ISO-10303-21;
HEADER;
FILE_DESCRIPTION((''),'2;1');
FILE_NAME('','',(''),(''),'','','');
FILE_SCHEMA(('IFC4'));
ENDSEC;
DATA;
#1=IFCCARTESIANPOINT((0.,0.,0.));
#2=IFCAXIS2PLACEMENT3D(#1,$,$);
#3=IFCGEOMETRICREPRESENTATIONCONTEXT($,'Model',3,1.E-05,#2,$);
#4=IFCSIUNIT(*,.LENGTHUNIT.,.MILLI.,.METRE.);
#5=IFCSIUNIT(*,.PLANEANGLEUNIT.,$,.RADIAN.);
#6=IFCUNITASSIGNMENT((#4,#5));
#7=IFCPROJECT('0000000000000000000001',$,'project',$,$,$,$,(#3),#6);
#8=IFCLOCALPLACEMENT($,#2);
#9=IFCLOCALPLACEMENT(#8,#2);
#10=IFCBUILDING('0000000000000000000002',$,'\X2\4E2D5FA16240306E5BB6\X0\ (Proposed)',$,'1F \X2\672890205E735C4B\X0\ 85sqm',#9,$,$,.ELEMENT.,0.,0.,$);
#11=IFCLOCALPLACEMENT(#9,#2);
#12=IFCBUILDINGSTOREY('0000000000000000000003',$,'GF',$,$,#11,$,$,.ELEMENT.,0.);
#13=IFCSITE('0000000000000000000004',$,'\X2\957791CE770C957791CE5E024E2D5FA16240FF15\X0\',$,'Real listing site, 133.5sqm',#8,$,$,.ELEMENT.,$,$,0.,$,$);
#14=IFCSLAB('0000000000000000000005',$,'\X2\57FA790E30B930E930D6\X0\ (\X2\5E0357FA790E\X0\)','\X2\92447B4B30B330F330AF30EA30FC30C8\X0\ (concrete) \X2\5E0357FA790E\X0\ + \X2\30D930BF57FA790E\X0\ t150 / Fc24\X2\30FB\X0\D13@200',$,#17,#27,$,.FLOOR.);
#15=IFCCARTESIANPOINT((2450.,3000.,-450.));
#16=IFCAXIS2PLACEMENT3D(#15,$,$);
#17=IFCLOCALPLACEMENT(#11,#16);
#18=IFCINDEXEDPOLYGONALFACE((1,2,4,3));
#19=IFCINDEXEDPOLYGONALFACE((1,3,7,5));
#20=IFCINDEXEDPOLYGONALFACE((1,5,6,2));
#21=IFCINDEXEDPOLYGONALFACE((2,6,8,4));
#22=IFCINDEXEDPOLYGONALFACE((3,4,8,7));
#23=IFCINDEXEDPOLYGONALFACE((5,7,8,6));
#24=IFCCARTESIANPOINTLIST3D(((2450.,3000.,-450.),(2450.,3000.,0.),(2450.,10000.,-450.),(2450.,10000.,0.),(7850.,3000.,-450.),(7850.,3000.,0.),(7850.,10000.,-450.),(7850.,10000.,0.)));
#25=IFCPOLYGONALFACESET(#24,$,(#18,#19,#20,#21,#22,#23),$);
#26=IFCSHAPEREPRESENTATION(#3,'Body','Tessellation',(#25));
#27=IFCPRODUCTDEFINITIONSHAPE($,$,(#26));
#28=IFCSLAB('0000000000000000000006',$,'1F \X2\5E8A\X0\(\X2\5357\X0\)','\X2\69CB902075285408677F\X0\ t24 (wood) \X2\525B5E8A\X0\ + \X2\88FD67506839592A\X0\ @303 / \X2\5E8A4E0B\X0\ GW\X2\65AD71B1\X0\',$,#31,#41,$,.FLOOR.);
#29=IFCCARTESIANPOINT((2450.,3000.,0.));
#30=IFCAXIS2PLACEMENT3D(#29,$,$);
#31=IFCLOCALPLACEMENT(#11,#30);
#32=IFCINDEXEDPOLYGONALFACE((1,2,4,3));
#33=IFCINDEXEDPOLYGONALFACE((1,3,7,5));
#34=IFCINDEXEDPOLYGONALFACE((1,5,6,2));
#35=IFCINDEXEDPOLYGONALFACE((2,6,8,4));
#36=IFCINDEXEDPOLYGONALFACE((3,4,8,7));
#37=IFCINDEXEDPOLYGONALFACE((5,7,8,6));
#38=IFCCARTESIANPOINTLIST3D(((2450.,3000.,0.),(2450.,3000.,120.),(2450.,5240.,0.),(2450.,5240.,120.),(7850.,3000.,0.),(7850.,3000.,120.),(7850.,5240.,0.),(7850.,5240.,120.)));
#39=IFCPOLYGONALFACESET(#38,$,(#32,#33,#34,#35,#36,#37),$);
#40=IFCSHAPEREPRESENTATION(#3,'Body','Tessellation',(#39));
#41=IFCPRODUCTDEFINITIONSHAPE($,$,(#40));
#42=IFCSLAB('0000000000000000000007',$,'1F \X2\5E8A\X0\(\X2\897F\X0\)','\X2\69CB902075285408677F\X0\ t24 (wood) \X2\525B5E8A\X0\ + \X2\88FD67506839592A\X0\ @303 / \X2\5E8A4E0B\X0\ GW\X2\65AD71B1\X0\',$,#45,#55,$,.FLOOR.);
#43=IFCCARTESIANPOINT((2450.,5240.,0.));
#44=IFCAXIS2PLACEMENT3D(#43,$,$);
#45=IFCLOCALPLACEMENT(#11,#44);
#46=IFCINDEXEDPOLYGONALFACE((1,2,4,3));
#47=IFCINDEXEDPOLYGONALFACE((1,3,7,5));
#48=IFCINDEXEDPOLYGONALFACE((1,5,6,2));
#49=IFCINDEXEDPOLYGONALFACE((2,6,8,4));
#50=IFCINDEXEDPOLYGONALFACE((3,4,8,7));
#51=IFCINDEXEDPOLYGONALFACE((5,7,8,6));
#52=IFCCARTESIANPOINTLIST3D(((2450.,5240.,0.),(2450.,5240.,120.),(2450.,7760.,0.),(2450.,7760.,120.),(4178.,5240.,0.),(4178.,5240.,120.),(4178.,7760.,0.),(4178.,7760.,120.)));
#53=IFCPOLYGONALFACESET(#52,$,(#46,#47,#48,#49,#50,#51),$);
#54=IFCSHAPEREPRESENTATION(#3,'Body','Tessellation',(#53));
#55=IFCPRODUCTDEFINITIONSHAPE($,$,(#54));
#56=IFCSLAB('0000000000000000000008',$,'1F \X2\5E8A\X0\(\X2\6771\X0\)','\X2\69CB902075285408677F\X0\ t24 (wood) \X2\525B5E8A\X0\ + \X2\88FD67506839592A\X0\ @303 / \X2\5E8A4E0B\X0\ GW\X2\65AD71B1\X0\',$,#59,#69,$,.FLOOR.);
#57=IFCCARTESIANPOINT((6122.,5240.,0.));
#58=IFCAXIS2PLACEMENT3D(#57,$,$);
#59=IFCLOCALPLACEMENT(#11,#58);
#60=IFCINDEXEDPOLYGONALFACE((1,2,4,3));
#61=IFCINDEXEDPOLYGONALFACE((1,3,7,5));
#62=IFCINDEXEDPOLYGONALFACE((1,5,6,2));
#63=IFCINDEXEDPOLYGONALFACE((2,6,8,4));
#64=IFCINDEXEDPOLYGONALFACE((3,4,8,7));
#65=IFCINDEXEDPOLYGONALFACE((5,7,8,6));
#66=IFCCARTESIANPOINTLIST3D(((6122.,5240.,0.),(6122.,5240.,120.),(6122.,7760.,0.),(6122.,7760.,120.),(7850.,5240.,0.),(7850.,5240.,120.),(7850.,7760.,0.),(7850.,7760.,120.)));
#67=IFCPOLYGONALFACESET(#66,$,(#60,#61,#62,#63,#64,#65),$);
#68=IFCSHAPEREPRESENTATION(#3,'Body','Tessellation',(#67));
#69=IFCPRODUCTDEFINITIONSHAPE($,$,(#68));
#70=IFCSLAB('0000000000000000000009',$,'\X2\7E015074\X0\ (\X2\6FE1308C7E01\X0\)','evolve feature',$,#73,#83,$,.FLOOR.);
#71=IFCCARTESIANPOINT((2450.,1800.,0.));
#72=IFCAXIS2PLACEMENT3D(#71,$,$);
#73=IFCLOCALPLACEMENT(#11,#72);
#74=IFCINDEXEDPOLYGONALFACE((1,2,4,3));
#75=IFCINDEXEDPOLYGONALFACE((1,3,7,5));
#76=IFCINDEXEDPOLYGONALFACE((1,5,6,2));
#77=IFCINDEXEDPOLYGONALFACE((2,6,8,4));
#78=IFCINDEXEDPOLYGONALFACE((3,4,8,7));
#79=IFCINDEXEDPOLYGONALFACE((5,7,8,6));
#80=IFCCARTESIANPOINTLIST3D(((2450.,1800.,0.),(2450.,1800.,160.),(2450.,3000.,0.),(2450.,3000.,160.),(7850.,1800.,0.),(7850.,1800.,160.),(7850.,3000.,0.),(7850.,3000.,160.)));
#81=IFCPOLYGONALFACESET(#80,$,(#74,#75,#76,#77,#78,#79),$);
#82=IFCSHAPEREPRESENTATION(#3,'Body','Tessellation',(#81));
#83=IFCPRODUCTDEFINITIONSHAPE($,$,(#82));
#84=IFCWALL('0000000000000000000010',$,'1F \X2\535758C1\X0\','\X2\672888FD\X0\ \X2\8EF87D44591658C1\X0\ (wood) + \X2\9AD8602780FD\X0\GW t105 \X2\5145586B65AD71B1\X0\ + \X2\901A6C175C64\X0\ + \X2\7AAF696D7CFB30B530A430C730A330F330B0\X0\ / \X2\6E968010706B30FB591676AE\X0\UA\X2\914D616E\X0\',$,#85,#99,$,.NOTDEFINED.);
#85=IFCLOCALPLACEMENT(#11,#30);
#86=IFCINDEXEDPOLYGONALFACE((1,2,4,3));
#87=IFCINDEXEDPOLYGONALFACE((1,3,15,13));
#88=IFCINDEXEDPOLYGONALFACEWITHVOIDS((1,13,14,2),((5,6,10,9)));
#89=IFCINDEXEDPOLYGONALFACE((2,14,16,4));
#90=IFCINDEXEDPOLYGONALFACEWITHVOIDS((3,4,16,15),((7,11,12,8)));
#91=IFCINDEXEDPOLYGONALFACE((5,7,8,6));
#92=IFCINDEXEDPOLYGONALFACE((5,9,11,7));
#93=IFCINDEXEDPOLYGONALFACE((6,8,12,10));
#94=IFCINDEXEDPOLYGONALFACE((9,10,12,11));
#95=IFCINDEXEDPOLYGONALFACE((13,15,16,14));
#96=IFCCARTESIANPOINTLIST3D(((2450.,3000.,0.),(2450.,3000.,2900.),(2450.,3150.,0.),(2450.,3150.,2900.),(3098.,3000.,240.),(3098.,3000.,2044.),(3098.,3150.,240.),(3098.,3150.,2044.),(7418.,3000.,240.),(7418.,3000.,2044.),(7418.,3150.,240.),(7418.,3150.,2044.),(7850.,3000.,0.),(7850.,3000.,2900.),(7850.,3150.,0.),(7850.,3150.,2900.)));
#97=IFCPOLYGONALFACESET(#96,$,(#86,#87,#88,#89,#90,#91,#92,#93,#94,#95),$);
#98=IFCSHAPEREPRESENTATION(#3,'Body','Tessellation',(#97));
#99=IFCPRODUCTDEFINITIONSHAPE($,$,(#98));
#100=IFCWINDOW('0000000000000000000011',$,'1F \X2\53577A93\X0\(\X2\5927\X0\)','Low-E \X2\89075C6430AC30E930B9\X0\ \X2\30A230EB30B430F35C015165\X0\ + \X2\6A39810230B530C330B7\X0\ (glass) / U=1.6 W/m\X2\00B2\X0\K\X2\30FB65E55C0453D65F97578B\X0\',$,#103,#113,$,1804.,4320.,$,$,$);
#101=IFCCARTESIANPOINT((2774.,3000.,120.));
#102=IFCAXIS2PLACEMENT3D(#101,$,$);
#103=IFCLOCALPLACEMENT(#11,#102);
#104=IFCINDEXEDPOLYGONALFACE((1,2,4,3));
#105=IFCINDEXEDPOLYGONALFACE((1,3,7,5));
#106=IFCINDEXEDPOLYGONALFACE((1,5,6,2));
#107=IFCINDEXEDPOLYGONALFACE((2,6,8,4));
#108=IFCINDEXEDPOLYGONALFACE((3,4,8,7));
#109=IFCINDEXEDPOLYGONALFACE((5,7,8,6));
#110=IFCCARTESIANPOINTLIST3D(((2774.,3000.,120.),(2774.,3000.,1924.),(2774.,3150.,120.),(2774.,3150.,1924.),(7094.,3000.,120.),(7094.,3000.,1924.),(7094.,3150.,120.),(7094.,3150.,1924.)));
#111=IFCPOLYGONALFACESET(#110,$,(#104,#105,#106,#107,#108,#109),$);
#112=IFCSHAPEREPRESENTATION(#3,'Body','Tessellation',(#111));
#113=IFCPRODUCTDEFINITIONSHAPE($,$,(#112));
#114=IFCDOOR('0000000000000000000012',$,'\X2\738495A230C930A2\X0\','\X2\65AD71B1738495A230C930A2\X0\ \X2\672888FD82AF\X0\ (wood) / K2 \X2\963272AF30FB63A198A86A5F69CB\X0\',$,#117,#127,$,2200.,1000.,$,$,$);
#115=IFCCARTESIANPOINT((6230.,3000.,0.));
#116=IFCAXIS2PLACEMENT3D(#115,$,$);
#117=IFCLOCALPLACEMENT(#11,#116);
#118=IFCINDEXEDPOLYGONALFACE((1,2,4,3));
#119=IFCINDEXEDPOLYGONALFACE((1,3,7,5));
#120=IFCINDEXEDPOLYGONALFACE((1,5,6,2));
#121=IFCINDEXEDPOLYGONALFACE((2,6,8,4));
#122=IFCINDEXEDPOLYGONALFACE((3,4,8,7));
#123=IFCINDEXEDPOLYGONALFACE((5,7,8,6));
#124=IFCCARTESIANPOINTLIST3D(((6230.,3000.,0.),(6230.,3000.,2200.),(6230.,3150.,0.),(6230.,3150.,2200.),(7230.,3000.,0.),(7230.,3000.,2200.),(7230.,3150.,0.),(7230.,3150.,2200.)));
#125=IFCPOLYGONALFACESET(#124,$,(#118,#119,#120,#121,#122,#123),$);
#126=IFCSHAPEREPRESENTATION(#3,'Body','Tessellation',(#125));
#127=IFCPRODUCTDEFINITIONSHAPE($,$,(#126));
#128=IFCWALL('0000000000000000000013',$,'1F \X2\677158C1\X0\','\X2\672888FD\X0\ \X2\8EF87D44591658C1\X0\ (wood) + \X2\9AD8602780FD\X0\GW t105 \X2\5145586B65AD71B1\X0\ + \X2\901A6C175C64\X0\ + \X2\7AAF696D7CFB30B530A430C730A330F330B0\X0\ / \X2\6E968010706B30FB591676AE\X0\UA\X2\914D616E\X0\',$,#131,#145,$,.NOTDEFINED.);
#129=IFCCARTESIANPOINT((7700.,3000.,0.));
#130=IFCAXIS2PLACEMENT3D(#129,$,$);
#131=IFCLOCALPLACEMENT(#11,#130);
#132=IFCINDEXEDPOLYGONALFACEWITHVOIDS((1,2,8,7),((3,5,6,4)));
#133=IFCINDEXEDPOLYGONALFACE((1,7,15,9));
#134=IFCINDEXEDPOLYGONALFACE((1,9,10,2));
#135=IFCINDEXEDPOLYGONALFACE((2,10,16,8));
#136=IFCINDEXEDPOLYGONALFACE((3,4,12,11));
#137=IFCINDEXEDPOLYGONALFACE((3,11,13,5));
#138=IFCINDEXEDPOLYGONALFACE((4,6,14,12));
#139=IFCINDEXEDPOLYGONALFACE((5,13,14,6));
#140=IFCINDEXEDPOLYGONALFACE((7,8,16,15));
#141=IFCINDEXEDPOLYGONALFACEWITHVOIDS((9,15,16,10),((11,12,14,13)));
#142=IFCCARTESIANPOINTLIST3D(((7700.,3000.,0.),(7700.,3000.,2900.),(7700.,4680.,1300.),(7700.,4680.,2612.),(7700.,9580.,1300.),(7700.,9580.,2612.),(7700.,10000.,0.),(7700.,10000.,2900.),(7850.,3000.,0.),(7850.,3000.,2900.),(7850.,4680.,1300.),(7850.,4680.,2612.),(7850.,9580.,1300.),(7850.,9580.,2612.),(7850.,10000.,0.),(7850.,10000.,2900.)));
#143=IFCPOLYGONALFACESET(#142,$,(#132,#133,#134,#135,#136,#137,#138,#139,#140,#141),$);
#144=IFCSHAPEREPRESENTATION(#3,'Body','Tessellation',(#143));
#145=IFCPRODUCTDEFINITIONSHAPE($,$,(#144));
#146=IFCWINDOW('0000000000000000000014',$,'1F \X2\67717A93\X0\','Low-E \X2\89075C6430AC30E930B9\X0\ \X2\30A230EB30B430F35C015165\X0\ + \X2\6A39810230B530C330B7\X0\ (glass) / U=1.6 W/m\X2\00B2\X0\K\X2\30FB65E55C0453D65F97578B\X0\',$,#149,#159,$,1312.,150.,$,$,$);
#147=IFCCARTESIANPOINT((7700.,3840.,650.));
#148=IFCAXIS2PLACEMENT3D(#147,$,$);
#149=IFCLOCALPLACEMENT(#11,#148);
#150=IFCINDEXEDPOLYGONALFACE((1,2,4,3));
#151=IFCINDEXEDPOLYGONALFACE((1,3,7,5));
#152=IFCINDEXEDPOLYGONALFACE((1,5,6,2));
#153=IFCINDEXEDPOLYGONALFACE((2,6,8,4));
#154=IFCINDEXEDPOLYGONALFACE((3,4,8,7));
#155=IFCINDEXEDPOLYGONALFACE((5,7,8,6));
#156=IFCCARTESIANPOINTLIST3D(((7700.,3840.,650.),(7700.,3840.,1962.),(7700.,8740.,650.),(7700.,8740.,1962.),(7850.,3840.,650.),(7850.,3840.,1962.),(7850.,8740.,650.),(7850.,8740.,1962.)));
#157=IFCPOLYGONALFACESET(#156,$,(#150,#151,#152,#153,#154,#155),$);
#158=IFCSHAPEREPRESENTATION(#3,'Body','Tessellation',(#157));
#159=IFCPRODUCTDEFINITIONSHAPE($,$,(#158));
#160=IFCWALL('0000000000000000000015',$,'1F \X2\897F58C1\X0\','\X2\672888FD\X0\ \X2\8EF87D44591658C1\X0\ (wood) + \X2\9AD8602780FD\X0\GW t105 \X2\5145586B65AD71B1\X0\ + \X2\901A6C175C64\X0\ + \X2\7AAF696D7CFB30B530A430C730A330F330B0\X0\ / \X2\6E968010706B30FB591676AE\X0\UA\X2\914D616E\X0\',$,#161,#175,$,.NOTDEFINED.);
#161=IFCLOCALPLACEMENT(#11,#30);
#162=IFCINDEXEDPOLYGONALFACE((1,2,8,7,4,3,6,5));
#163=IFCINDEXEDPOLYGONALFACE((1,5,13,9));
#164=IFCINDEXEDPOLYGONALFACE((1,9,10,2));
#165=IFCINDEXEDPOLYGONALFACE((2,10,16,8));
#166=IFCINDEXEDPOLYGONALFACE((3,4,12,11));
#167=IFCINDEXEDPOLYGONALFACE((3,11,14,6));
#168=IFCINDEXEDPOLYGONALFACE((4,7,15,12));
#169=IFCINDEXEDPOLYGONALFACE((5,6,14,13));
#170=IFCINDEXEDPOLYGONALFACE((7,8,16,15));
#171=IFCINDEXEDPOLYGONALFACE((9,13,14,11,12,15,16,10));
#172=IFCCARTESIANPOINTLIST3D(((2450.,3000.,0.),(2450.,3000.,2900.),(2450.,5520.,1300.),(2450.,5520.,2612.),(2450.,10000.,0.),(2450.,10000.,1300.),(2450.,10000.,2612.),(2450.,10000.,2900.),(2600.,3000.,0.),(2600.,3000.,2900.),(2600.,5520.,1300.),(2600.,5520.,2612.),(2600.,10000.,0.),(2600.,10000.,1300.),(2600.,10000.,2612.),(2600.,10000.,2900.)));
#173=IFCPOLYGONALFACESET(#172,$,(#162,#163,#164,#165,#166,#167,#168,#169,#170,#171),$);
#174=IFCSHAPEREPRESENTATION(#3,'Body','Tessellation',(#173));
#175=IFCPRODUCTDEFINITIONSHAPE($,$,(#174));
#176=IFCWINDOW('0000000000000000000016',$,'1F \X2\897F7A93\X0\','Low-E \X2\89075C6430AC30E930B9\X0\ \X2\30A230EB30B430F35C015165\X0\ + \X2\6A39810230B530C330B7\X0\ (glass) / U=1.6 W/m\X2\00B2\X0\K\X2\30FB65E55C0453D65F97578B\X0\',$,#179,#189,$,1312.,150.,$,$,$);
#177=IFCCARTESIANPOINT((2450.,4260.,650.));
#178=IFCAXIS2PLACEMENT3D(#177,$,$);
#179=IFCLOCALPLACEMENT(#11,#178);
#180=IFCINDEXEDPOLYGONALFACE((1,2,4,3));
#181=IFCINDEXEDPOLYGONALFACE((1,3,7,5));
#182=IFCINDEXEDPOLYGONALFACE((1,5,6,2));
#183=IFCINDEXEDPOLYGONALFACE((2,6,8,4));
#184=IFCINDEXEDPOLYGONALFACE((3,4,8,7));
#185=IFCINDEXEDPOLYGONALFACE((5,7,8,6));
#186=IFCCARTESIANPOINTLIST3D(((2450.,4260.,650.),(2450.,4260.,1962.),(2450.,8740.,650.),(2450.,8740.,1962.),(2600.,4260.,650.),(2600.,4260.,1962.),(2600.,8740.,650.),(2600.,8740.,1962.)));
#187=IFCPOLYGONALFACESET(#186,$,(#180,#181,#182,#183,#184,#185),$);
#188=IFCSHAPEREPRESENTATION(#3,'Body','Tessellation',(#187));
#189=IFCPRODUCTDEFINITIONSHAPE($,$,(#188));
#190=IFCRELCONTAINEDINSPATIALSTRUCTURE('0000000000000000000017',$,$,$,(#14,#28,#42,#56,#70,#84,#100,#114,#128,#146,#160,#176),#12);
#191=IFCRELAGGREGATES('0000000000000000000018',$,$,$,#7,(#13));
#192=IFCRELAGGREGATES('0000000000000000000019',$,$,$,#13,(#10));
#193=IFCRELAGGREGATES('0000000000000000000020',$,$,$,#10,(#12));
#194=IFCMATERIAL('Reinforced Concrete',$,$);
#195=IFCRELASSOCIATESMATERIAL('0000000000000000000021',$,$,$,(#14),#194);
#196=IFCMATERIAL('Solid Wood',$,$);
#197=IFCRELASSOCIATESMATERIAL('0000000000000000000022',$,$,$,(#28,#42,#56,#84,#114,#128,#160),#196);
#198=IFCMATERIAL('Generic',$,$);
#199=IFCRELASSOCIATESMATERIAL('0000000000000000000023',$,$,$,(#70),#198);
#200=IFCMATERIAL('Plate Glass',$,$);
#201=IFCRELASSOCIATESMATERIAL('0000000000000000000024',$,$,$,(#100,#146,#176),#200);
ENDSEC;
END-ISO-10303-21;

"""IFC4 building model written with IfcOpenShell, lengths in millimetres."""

from ifc_helpers import new_model, si_unit, frame, frame_2d, origin, place, context, project, spatial, rectangle, extrude, material, element, fill, save


model = new_model("IFC4")

# Units and contexts
model_context = context("Model", 3, precision=1e-05, world=origin())
ifc_project = project(units=[si_unit("LENGTHUNIT", "METRE", prefix="MILLI"), si_unit("PLANEANGLEUNIT", "RADIAN")], contexts=[model_context])

# Site, building, storey
site_placement = place(None, origin())
site = spatial("IfcSite", under=ifc_project, at=site_placement, Name="長野県長野市中御所５", ObjectType="Real listing site, 133.5sqm", CompositionType="ELEMENT", RefElevation=0.0)
building_placement = place(site_placement, origin())
building = spatial("IfcBuilding", under=site, at=building_placement, Name="中御所の家 (Proposed)", ObjectType="1F 木造平屋 85sqm", CompositionType="ELEMENT", ElevationOfRefHeight=0.0, ElevationOfTerrain=0.0)
storey_placement = place(building_placement, origin())
storey = spatial("IfcBuildingStorey", under=building, at=storey_placement, Name="GF", CompositionType="ELEMENT", Elevation=0.0)

# Slabs
ifc_material_1 = material(Name="Reinforced Concrete")
slab_1_placement = place(storey_placement, frame((2450.0, 3000.0, -450.0)))
element("IfcSlab", 1, at=slab_1_placement, inside=storey, material=ifc_material_1, Name="基礎スラブ (布基礎)", Description="鉄筋コンクリート (concrete) 布基礎 + ベタ基礎 t150 / Fc24・D13@200", PredefinedType="FLOOR", context=model_context, shape_type="SweptSolid", body=[
    extrude(rectangle(XDim=5400.0, YDim=7000.0, at=frame_2d((2700.0, 3500.0))), frame((2450.0, 3000.0, -450.0)), (0.0, 0.0, 1.0), 450.0),
])
ifc_material_2 = material(Name="Solid Wood")
slab_2_placement = place(storey_placement, frame((2450.0, 3000.0, 0.0)))
element("IfcSlab", 2, at=slab_2_placement, inside=storey, material=ifc_material_2, Name="1F 床(南)", Description="構造用合板 t24 (wood) 剛床 + 製材根太 @303 / 床下 GW断熱", PredefinedType="FLOOR", context=model_context, shape_type="SweptSolid", body=[
    extrude(rectangle(XDim=5400.0, YDim=2240.0, at=frame_2d((2700.0, 1120.0))), frame((2450.0, 3000.0, 0.0)), (0.0, 0.0, 1.0), 120.0),
])
slab_3_placement = place(storey_placement, frame((2450.0, 5240.0, 0.0)))
element("IfcSlab", 3, at=slab_3_placement, inside=storey, material=ifc_material_2, Name="1F 床(西)", Description="構造用合板 t24 (wood) 剛床 + 製材根太 @303 / 床下 GW断熱", PredefinedType="FLOOR", context=model_context, shape_type="SweptSolid", body=[
    extrude(rectangle(XDim=1728.0, YDim=2520.0, at=frame_2d((864.0, 1260.0))), frame((2450.0, 5240.0, 0.0)), (0.0, 0.0, 1.0), 120.0),
])
slab_4_placement = place(storey_placement, frame((6122.0, 5240.0, 0.0)))
element("IfcSlab", 4, at=slab_4_placement, inside=storey, material=ifc_material_2, Name="1F 床(東)", Description="構造用合板 t24 (wood) 剛床 + 製材根太 @303 / 床下 GW断熱", PredefinedType="FLOOR", context=model_context, shape_type="SweptSolid", body=[
    extrude(rectangle(XDim=1728.0, YDim=2520.0, at=frame_2d((864.0, 1260.0))), frame((6122.0, 5240.0, 0.0)), (0.0, 0.0, 1.0), 120.0),
])
ifc_material_3 = material(Name="Generic")
slab_5_placement = place(storey_placement, frame((2450.0, 1800.0, 0.0)))
element("IfcSlab", 5, at=slab_5_placement, inside=storey, material=ifc_material_3, Name="縁側 (濡れ縁)", Description="evolve feature", PredefinedType="FLOOR", context=model_context, shape_type="SweptSolid", body=[
    extrude(rectangle(XDim=5400.0, YDim=1200.0, at=frame_2d((2700.0, 600.0))), frame((2450.0, 1800.0, 0.0)), (0.0, 0.0, 1.0), 160.0),
])

# Wall, openings, window, door
wall_1_placement = place(storey_placement, frame((2450.0, 3000.0, 0.0)))
wall_1 = element("IfcWall", 6, at=wall_1_placement, inside=storey, material=ifc_material_2, Name="1F 南壁", Description="木製 軸組外壁 (wood) + 高性能GW t105 充填断熱 + 通気層 + 窯業系サイディング / 準耐火・外皮UA配慮", PredefinedType="NOTDEFINED", context=model_context, shape_type="SweptSolid", body=[
    extrude(rectangle(XDim=5400.0, YDim=150.0, at=frame_2d((2700.0, 75.0))), frame((2450.0, 3000.0, 0.0)), (0.0, 0.0, 1.0), 2900.0),
])
opening_1_placement = place(storey_placement, frame((2774.0, 3000.0, 120.0)))
opening_1 = element("IfcOpeningElement", 7, at=opening_1_placement, cuts=wall_1, PredefinedType="NOTDEFINED", context=model_context, shape_type="SweptSolid", body=[
    extrude(rectangle(XDim=4320.0, YDim=150.0, at=frame_2d((2160.0, 75.0))), frame((2774.0, 3000.0, 120.0)), (0.0, 0.0, 1.0), 1804.0),
])
opening_2_placement = place(storey_placement, frame((6230.0, 3000.0, 0.0)))
opening_2 = element("IfcOpeningElement", 8, at=opening_2_placement, cuts=wall_1, PredefinedType="NOTDEFINED", context=model_context, shape_type="SweptSolid", body=[
    extrude(rectangle(XDim=1000.0, YDim=150.0, at=frame_2d((500.0, 75.0))), frame((6230.0, 3000.0, 0.0)), (0.0, 0.0, 1.0), 2200.0),
])
ifc_material_4 = material(Name="Plate Glass")
window_1_placement = place(storey_placement, frame((2774.0, 3000.0, 120.0)))
window_1 = element("IfcWindow", 9, at=window_1_placement, inside=storey, material=ifc_material_4, Name="1F 南窓(大)", Description="Low-E 複層ガラス アルゴン封入 + 樹脂サッシ (glass) / U=1.6 W/m²K・日射取得型", OverallHeight=1804.0, OverallWidth=4320.0, context=model_context, shape_type="SweptSolid", body=[
    extrude(rectangle(XDim=4320.0, YDim=150.0, at=frame_2d((2160.0, 75.0))), frame((2774.0, 3000.0, 120.0)), (0.0, 0.0, 1.0), 1804.0),
])
fill(opening_1, window_1)
door_placement = place(storey_placement, frame((6230.0, 3000.0, 0.0)))
door = element("IfcDoor", 10, at=door_placement, inside=storey, material=ifc_material_2, Name="玄関ドア", Description="断熱玄関ドア 木製芯 (wood) / K2 防犯・採風機構", OverallHeight=2200.0, OverallWidth=1000.0, context=model_context, shape_type="SweptSolid", body=[
    extrude(rectangle(XDim=1000.0, YDim=150.0, at=frame_2d((500.0, 75.0))), frame((6230.0, 3000.0, 0.0)), (0.0, 0.0, 1.0), 2200.0),
])
fill(opening_2, door)

# Walls, openings, windows
wall_2_placement = place(storey_placement, frame((7700.0, 3000.0, 0.0)))
wall_2 = element("IfcWall", 11, at=wall_2_placement, inside=storey, material=ifc_material_2, Name="1F 東壁", Description="木製 軸組外壁 (wood) + 高性能GW t105 充填断熱 + 通気層 + 窯業系サイディング / 準耐火・外皮UA配慮", PredefinedType="NOTDEFINED", context=model_context, shape_type="SweptSolid", body=[
    extrude(rectangle(XDim=150.0, YDim=7000.0, at=frame_2d((75.0, 3500.0))), frame((7700.0, 3000.0, 0.0)), (0.0, 0.0, 1.0), 2900.0),
])
opening_3_placement = place(storey_placement, frame((7700.0, 3840.0, 650.0)))
opening_3 = element("IfcOpeningElement", 12, at=opening_3_placement, cuts=wall_2, PredefinedType="NOTDEFINED", context=model_context, shape_type="SweptSolid", body=[
    extrude(rectangle(XDim=150.0, YDim=4900.0, at=frame_2d((75.0, 2450.0))), frame((7700.0, 3840.0, 650.0)), (0.0, 0.0, 1.0), 1312.0),
])
window_2_placement = place(storey_placement, frame((7700.0, 3840.0, 650.0)))
window_2 = element("IfcWindow", 13, at=window_2_placement, inside=storey, material=ifc_material_4, Name="1F 東窓", Description="Low-E 複層ガラス アルゴン封入 + 樹脂サッシ (glass) / U=1.6 W/m²K・日射取得型", OverallHeight=1312.0, OverallWidth=150.0, context=model_context, shape_type="SweptSolid", body=[
    extrude(rectangle(XDim=150.0, YDim=4900.0, at=frame_2d((75.0, 2450.0))), frame((7700.0, 3840.0, 650.0)), (0.0, 0.0, 1.0), 1312.0),
])
fill(opening_3, window_2)
wall_3_placement = place(storey_placement, frame((2450.0, 3000.0, 0.0)))
wall_3 = element("IfcWall", 14, at=wall_3_placement, inside=storey, material=ifc_material_2, Name="1F 西壁", Description="木製 軸組外壁 (wood) + 高性能GW t105 充填断熱 + 通気層 + 窯業系サイディング / 準耐火・外皮UA配慮", PredefinedType="NOTDEFINED", context=model_context, shape_type="SweptSolid", body=[
    extrude(rectangle(XDim=150.0, YDim=7000.0, at=frame_2d((75.0, 3500.0))), frame((2450.0, 3000.0, 0.0)), (0.0, 0.0, 1.0), 2900.0),
])
opening_4_placement = place(storey_placement, frame((2450.0, 4260.0, 650.0)))
opening_4 = element("IfcOpeningElement", 15, at=opening_4_placement, cuts=wall_3, PredefinedType="NOTDEFINED", context=model_context, shape_type="SweptSolid", body=[
    extrude(rectangle(XDim=150.0, YDim=4480.0, at=frame_2d((75.0, 2240.0))), frame((2450.0, 4260.0, 650.0)), (0.0, 0.0, 1.0), 1312.0),
])
window_3_placement = place(storey_placement, frame((2450.0, 4260.0, 650.0)))
window_3 = element("IfcWindow", 16, at=window_3_placement, inside=storey, material=ifc_material_4, Name="1F 西窓", Description="Low-E 複層ガラス アルゴン封入 + 樹脂サッシ (glass) / U=1.6 W/m²K・日射取得型", OverallHeight=1312.0, OverallWidth=150.0, context=model_context, shape_type="SweptSolid", body=[
    extrude(rectangle(XDim=150.0, YDim=4480.0, at=frame_2d((75.0, 2240.0))), frame((2450.0, 4260.0, 650.0)), (0.0, 0.0, 1.0), 1312.0),
])
fill(opening_4, window_3)

save(model, "model.ifc")
